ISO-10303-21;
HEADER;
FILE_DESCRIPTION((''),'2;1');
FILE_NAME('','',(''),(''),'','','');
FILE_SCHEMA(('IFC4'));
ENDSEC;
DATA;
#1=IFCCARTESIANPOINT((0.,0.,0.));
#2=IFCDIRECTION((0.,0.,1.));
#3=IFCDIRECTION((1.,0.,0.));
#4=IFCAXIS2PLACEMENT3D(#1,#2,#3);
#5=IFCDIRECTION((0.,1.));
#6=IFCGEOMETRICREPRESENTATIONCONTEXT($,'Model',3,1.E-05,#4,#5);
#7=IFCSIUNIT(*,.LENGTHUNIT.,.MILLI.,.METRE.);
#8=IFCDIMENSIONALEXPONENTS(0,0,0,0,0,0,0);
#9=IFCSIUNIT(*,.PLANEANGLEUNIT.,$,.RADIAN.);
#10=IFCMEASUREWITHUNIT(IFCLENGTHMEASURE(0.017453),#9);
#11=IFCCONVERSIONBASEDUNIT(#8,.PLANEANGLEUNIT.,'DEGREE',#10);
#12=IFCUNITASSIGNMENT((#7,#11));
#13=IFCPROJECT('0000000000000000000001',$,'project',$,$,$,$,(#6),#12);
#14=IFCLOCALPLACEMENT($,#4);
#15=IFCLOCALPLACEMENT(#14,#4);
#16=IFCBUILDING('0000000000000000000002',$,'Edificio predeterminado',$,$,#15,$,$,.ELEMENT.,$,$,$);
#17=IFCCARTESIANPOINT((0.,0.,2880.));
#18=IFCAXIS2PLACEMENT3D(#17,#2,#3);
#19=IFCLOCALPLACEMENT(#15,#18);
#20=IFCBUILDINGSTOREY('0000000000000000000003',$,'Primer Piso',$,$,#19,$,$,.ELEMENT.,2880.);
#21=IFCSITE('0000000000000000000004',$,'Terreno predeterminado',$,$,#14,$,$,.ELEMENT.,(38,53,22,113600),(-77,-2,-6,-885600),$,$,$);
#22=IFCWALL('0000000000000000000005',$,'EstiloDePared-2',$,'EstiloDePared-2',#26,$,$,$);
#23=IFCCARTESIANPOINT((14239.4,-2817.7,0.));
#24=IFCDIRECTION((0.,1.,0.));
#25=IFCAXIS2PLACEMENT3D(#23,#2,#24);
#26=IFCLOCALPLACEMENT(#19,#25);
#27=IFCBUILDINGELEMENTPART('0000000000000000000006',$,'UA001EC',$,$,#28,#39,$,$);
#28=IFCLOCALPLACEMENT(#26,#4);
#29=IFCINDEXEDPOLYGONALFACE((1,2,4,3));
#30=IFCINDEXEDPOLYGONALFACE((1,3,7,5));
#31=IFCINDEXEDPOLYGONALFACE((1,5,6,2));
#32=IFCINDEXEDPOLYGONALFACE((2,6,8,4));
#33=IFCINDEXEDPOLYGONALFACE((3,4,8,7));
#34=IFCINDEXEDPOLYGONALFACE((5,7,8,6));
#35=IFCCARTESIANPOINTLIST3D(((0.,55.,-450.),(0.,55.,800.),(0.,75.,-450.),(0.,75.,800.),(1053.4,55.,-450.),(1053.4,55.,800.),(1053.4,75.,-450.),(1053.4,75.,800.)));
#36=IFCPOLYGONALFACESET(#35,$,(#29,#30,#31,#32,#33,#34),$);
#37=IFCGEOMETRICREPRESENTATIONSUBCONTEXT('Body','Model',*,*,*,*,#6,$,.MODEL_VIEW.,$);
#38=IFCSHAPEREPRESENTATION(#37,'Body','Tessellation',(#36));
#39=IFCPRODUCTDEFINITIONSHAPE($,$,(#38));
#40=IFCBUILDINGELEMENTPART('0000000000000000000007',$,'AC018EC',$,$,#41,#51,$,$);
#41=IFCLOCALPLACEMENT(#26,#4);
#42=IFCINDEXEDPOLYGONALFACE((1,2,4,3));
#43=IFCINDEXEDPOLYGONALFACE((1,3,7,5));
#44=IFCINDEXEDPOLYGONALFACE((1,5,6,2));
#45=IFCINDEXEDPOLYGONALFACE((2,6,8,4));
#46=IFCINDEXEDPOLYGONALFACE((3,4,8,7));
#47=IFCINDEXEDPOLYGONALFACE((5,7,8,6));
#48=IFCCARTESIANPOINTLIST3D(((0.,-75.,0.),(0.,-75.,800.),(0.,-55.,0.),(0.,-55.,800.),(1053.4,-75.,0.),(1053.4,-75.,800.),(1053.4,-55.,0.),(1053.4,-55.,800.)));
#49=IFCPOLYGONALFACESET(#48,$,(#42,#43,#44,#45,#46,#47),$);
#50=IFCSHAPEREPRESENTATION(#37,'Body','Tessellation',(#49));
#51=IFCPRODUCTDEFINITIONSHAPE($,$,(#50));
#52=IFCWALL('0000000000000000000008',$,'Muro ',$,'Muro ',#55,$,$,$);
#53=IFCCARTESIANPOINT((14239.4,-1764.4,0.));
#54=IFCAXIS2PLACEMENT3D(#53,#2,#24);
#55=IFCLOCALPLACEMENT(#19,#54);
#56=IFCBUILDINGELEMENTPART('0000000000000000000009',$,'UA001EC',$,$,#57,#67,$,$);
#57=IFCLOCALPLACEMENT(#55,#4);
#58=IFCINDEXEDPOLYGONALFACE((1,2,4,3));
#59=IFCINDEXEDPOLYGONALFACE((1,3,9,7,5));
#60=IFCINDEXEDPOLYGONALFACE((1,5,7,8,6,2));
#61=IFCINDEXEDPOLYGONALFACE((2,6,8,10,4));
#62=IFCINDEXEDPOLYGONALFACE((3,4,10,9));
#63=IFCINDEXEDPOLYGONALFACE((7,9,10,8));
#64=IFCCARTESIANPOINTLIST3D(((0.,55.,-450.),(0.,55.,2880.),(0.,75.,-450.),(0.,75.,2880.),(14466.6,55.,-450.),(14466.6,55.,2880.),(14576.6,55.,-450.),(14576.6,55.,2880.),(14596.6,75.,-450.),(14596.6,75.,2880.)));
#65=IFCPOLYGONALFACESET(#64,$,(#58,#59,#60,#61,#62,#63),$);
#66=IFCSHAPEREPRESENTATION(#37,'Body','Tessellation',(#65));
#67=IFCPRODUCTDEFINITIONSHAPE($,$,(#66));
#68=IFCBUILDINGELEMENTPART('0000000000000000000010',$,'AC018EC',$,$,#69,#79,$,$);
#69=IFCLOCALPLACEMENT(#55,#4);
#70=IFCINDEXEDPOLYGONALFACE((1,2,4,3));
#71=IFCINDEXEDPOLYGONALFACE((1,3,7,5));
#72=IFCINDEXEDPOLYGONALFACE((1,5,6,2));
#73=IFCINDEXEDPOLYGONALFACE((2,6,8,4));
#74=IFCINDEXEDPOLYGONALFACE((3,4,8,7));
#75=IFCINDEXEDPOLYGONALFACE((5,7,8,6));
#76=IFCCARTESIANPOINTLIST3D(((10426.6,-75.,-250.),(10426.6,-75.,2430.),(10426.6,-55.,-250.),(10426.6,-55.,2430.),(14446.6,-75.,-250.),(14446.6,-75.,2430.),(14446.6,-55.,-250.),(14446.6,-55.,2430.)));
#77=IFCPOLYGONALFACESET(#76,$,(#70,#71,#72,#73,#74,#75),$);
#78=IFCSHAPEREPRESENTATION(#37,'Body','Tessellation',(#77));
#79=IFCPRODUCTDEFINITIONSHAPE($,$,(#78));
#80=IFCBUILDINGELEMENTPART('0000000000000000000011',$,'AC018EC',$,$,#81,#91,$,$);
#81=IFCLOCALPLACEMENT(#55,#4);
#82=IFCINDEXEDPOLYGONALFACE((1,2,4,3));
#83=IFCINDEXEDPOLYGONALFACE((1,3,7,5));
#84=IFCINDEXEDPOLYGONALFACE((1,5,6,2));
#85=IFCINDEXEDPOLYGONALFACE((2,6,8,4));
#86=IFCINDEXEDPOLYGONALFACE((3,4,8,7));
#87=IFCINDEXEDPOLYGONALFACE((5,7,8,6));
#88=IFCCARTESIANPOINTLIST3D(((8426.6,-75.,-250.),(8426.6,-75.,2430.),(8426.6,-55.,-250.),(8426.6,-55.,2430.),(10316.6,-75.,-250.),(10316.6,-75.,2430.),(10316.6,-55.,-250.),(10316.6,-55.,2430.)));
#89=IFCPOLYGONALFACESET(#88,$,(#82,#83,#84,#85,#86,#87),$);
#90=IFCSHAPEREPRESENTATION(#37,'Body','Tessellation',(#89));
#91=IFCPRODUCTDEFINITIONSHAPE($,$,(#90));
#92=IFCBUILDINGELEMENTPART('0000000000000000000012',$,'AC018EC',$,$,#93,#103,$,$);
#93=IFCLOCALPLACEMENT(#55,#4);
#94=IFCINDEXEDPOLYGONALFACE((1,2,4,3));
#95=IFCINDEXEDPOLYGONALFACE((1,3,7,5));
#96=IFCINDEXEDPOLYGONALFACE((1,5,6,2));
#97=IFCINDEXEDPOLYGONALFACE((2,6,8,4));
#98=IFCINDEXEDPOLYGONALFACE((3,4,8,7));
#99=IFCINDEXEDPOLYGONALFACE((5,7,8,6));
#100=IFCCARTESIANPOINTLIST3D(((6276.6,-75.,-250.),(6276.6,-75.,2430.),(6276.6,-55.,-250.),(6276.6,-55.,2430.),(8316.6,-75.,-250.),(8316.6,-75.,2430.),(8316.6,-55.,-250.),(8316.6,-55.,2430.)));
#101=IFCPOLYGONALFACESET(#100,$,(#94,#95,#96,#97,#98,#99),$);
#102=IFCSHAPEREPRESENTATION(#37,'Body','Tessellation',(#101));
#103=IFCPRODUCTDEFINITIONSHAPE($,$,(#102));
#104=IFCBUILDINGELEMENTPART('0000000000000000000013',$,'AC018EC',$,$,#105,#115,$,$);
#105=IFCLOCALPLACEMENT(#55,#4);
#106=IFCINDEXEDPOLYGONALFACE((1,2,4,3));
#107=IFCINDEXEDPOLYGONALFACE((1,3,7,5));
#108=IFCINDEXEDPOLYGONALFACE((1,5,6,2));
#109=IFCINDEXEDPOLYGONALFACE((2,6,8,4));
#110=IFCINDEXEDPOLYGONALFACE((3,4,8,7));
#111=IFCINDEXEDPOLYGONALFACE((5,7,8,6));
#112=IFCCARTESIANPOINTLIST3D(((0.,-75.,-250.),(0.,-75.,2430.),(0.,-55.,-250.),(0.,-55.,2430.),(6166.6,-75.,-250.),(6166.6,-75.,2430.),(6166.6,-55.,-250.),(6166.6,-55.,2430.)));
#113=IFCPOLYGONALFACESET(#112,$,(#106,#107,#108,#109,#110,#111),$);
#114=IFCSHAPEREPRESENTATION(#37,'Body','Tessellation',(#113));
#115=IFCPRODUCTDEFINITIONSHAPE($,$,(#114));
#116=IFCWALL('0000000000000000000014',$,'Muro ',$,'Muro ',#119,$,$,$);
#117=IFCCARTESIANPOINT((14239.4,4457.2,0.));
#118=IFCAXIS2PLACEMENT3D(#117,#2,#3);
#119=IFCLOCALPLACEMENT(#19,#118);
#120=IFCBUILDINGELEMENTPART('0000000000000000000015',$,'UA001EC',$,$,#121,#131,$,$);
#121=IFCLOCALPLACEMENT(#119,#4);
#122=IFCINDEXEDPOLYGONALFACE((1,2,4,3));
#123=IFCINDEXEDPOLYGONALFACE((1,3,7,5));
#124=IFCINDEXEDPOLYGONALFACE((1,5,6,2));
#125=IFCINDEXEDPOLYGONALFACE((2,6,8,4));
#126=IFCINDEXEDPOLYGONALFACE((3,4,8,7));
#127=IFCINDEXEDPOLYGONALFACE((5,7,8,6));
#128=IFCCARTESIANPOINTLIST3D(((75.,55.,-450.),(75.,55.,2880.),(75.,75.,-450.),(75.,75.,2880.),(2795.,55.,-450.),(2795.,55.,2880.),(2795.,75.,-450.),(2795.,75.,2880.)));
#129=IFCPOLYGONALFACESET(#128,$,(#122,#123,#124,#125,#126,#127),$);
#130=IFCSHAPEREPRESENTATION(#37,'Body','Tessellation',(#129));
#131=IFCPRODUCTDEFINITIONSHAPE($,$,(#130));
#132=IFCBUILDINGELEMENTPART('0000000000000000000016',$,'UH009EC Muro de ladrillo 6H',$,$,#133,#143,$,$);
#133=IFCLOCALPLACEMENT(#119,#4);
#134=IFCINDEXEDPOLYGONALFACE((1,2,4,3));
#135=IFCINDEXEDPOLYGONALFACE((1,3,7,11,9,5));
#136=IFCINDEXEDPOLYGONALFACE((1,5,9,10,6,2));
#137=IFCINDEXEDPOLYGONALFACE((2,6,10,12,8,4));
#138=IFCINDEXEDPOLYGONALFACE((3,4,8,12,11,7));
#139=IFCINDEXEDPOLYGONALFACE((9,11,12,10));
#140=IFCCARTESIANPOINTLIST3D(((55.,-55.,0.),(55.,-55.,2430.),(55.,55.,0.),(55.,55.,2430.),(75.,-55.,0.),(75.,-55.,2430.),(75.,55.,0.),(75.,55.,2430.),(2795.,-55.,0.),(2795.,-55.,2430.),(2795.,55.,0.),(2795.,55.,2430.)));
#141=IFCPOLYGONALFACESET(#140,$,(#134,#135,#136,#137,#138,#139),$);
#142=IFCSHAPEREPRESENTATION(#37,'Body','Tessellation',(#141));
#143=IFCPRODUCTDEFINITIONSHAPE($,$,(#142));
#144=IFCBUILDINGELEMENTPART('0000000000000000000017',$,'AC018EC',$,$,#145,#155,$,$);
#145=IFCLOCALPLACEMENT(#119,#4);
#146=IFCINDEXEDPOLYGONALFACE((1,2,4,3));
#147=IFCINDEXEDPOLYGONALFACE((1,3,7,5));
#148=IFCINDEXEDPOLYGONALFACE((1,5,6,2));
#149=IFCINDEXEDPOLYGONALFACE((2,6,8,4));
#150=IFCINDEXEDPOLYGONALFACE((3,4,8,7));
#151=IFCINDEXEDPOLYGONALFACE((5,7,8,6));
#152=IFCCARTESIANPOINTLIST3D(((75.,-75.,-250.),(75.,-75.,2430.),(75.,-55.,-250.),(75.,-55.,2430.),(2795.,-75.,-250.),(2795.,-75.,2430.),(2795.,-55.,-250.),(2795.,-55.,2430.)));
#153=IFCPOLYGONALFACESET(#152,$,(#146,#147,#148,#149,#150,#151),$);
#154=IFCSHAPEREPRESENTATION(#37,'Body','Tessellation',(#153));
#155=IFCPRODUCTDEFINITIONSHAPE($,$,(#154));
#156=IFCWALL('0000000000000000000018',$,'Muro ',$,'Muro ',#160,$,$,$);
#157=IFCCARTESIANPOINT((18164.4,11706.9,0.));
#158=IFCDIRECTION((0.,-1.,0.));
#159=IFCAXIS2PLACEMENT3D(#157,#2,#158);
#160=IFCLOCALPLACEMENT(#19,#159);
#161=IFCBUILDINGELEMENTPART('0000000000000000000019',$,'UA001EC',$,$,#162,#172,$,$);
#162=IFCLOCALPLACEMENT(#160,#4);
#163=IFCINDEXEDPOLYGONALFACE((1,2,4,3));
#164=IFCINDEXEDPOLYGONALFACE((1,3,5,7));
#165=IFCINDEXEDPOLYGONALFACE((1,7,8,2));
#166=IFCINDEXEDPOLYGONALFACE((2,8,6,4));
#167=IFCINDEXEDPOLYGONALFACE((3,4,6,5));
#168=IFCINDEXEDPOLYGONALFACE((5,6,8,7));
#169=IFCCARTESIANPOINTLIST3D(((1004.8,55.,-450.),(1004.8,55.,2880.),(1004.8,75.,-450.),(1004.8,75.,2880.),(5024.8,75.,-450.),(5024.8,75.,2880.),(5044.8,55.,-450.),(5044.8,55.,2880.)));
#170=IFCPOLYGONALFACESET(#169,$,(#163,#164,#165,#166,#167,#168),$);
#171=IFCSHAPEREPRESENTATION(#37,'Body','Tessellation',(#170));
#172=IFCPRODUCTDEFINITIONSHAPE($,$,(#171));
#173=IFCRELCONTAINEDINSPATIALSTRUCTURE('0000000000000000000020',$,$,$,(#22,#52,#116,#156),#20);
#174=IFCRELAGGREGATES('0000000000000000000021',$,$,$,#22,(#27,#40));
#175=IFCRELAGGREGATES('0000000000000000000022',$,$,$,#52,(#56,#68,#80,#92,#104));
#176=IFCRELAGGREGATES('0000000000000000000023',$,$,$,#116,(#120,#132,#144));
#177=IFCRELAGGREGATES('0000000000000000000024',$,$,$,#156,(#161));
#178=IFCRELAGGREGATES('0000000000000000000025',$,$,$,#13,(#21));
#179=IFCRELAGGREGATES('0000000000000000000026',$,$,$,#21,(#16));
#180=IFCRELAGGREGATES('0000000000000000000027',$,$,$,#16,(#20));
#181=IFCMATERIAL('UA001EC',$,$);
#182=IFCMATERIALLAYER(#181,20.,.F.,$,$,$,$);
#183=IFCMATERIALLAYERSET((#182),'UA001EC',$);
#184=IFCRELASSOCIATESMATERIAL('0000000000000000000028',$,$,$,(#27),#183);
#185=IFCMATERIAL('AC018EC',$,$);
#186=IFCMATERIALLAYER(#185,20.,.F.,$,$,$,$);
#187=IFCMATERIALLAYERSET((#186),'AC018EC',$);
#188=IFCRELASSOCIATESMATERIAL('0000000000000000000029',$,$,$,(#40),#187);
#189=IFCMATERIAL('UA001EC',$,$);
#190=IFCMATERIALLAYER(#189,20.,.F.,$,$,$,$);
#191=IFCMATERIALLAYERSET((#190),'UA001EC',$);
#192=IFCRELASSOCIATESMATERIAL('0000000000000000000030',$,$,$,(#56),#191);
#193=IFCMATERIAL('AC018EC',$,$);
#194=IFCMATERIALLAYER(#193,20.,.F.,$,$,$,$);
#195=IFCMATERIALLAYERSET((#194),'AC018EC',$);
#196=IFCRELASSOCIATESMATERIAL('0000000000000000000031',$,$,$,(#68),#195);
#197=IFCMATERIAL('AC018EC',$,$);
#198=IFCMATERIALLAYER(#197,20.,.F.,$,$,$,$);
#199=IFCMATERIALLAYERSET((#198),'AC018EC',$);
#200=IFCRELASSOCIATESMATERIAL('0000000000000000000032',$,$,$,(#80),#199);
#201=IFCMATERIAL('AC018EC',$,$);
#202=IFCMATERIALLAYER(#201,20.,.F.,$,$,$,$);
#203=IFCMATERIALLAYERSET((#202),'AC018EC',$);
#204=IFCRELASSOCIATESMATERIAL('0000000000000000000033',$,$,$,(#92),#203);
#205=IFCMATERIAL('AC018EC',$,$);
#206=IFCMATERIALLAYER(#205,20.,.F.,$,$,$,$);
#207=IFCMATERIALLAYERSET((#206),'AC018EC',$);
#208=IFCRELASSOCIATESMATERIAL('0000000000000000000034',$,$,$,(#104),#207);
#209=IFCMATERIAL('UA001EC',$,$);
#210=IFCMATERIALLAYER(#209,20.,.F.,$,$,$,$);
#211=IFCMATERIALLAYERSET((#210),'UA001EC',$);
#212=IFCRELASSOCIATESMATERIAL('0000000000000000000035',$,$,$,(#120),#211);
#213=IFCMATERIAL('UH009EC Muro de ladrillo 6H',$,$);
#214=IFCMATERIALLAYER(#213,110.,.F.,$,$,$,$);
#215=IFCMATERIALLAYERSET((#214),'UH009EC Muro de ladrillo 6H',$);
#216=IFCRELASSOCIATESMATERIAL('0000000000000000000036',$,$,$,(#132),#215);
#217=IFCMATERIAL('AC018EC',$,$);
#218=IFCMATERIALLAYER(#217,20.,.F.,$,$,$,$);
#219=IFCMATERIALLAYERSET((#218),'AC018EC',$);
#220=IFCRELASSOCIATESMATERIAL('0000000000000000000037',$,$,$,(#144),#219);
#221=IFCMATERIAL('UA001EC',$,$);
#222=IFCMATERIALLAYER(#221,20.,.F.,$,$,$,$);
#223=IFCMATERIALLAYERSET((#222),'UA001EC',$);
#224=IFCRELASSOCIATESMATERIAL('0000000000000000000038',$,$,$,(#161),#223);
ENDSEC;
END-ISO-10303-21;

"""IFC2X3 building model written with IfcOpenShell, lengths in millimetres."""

from ifc_helpers import new_model, entity, si_unit, converted_unit, direction, frame, origin_with_axes, place, context, subcontext, project, spatial, polyline, outline, extrude, material, layer, layer_set, layer_usage, element, aggregate, save


model = new_model("IFC2X3")

# Units and contexts
model_context = context("Model", 3, precision=1e-05, world=origin_with_axes(), true_north=direction((0.0, 1.0)))
body_context = subcontext(model_context, "Body", "Model", "MODEL_VIEW")
ifc_project = project(units=[si_unit("LENGTHUNIT", "METRE", prefix="MILLI"), converted_unit("PLANEANGLEUNIT", "DEGREE", entity("IfcLengthMeasure", 0.017453), si_unit("PLANEANGLEUNIT", "RADIAN"), dimensions=[0, 0, 0, 0, 0, 0, 0])], contexts=[model_context])

# Site, building, storey
site_placement = place(None, origin_with_axes())
site = spatial("IfcSite", under=ifc_project, at=site_placement, Name="Terreno predeterminado", CompositionType="ELEMENT", RefLatitude=(38, 53, 22, 113600), RefLongitude=(-77, -2, -6, -885600))
building_placement = place(site_placement, origin_with_axes())
building = spatial("IfcBuilding", under=site, at=building_placement, Name="Edificio predeterminado", CompositionType="ELEMENT")
storey_placement = place(building_placement, frame((0.0, 0.0, 2880.0), z_axis=(0.0, 0.0, 1.0), x_axis=(1.0, 0.0, 0.0)))
storey = spatial("IfcBuildingStorey", under=building, at=storey_placement, Name="Primer Piso", CompositionType="ELEMENT", Elevation=2880.0)

# Walls, building element parts
wall_1_placement = place(storey_placement, frame((14239.4, -2817.7, 0.0), z_axis=(0.0, 0.0, 1.0), x_axis=(0.0, 1.0, 0.0)))
wall_1 = element("IfcWall", 1, at=wall_1_placement, inside=storey, Name="EstiloDePared-2", ObjectType="EstiloDePared-2")
ifc_material_1 = material(Name="UA001EC")
ifc_layer_1 = layer(ifc_material_1, 20.0, ventilated=False)
ifc_layer_set_1 = layer_set([ifc_layer_1], Name="UA001EC")
ifc_layer_usage_1 = layer_usage(ifc_layer_set_1, "AXIS2", "NEGATIVE", -75.0)
building_element_part_1_placement = place(wall_1_placement, origin_with_axes())
building_element_part_1 = element("IfcBuildingElementPart", 2, at=building_element_part_1_placement, material=ifc_layer_usage_1, Name="UA001EC", context=body_context, shape_type="SweptSolid", body=[
    extrude(outline(polyline([(1053.4, 75.0), (1053.4, 55.0), (0.0, 55.0), (0.0, 75.0), (1053.4, 75.0)])), frame((0.0, 0.0, -450.0), z_axis=(0.0, 0.0, 1.0), x_axis=(1.0, 0.0, 0.0)), (0.0, 0.0, 1.0), 1250.0),
])
ifc_material_2 = material(Name="AC018EC")
ifc_layer_2 = layer(ifc_material_2, 20.0, ventilated=False)
ifc_layer_set_2 = layer_set([ifc_layer_2], Name="AC018EC")
ifc_layer_usage_2 = layer_usage(ifc_layer_set_2, "AXIS2", "NEGATIVE", 55.0)
building_element_part_2_placement = place(wall_1_placement, origin_with_axes())
building_element_part_2 = element("IfcBuildingElementPart", 3, at=building_element_part_2_placement, material=ifc_layer_usage_2, Name="AC018EC", context=body_context, shape_type="SweptSolid", body=[
    extrude(outline(polyline([(1053.4, -55.0), (1053.4, -75.0), (0.0, -75.0), (0.0, -55.0), (1053.4, -55.0)])), origin_with_axes(), (0.0, 0.0, 1.0), 800.0),
])
aggregate(wall_1, [building_element_part_1, building_element_part_2])
wall_2_placement = place(storey_placement, frame((14239.4, -1764.4, 0.0), z_axis=(0.0, 0.0, 1.0), x_axis=(0.0, 1.0, 0.0)))
wall_2 = element("IfcWall", 4, at=wall_2_placement, inside=storey, Name="Muro ", ObjectType="Muro ")
ifc_material_3 = material(Name="UA001EC")
ifc_layer_3 = layer(ifc_material_3, 20.0, ventilated=False)
ifc_layer_set_3 = layer_set([ifc_layer_3], Name="UA001EC")
ifc_layer_usage_3 = layer_usage(ifc_layer_set_3, "AXIS2", "NEGATIVE", -75.0)
building_element_part_3_placement = place(wall_2_placement, origin_with_axes())
building_element_part_3 = element("IfcBuildingElementPart", 5, at=building_element_part_3_placement, material=ifc_layer_usage_3, Name="UA001EC", context=body_context, shape_type="SweptSolid", body=[
    extrude(outline(polyline([(14596.6, 75.0), (14576.6, 55.0), (14466.6, 55.0), (0.0, 55.0), (0.0, 75.0), (14596.6, 75.0)])), frame((0.0, 0.0, -450.0), z_axis=(0.0, 0.0, 1.0), x_axis=(1.0, 0.0, 0.0)), (0.0, 0.0, 1.0), 3330.0),
])
ifc_material_4 = material(Name="AC018EC")
ifc_layer_4 = layer(ifc_material_4, 20.0, ventilated=False)
ifc_layer_set_4 = layer_set([ifc_layer_4], Name="AC018EC")
ifc_layer_usage_4 = layer_usage(ifc_layer_set_4, "AXIS2", "NEGATIVE", 55.0)
building_element_part_4_placement = place(wall_2_placement, origin_with_axes())
building_element_part_4 = element("IfcBuildingElementPart", 6, at=building_element_part_4_placement, material=ifc_layer_usage_4, Name="AC018EC", context=body_context, shape_type="SweptSolid", body=[
    extrude(outline(polyline([(14446.6, -55.0), (14446.6, -75.0), (10426.6, -75.0), (10426.6, -55.0), (14446.6, -55.0)])), frame((0.0, 0.0, -250.0), z_axis=(0.0, 0.0, 1.0), x_axis=(1.0, 0.0, 0.0)), (0.0, 0.0, 1.0), 2680.0),
])
ifc_material_5 = material(Name="AC018EC")
ifc_layer_5 = layer(ifc_material_5, 20.0, ventilated=False)
ifc_layer_set_5 = layer_set([ifc_layer_5], Name="AC018EC")
ifc_layer_usage_5 = layer_usage(ifc_layer_set_5, "AXIS2", "NEGATIVE", 55.0)
building_element_part_5_placement = place(wall_2_placement, origin_with_axes())
building_element_part_5 = element("IfcBuildingElementPart", 7, at=building_element_part_5_placement, material=ifc_layer_usage_5, Name="AC018EC", context=body_context, shape_type="SweptSolid", body=[
    extrude(outline(polyline([(10316.6, -55.0), (10316.6, -75.0), (8426.6, -75.0), (8426.6, -55.0), (10316.6, -55.0)])), frame((0.0, 0.0, -250.0), z_axis=(0.0, 0.0, 1.0), x_axis=(1.0, 0.0, 0.0)), (0.0, 0.0, 1.0), 2680.0),
])
ifc_material_6 = material(Name="AC018EC")
ifc_layer_6 = layer(ifc_material_6, 20.0, ventilated=False)
ifc_layer_set_6 = layer_set([ifc_layer_6], Name="AC018EC")
ifc_layer_usage_6 = layer_usage(ifc_layer_set_6, "AXIS2", "NEGATIVE", 55.0)
building_element_part_6_placement = place(wall_2_placement, origin_with_axes())
building_element_part_6 = element("IfcBuildingElementPart", 8, at=building_element_part_6_placement, material=ifc_layer_usage_6, Name="AC018EC", context=body_context, shape_type="SweptSolid", body=[
    extrude(outline(polyline([(8316.6, -55.0), (8316.6, -75.0), (6276.6, -75.0), (6276.6, -55.0), (8316.6, -55.0)])), frame((0.0, 0.0, -250.0), z_axis=(0.0, 0.0, 1.0), x_axis=(1.0, 0.0, 0.0)), (0.0, 0.0, 1.0), 2680.0),
])
ifc_material_7 = material(Name="AC018EC")
ifc_layer_7 = layer(ifc_material_7, 20.0, ventilated=False)
ifc_layer_set_7 = layer_set([ifc_layer_7], Name="AC018EC")
ifc_layer_usage_7 = layer_usage(ifc_layer_set_7, "AXIS2", "NEGATIVE", 55.0)
building_element_part_7_placement = place(wall_2_placement, origin_with_axes())
building_element_part_7 = element("IfcBuildingElementPart", 9, at=building_element_part_7_placement, material=ifc_layer_usage_7, Name="AC018EC", context=body_context, shape_type="SweptSolid", body=[
    extrude(outline(polyline([(6166.6, -55.0), (6166.6, -75.0), (0.0, -75.0), (0.0, -55.0), (6166.6, -55.0)])), frame((0.0, 0.0, -250.0), z_axis=(0.0, 0.0, 1.0), x_axis=(1.0, 0.0, 0.0)), (0.0, 0.0, 1.0), 2680.0),
])
aggregate(wall_2, [building_element_part_3, building_element_part_4, building_element_part_5, building_element_part_6, building_element_part_7])
wall_3_placement = place(storey_placement, frame((14239.4, 4457.2, 0.0), z_axis=(0.0, 0.0, 1.0), x_axis=(1.0, 0.0, 0.0)))
wall_3 = element("IfcWall", 10, at=wall_3_placement, inside=storey, Name="Muro ", ObjectType="Muro ")
ifc_material_8 = material(Name="UA001EC")
ifc_layer_8 = layer(ifc_material_8, 20.0, ventilated=False)
ifc_layer_set_8 = layer_set([ifc_layer_8], Name="UA001EC")
ifc_layer_usage_8 = layer_usage(ifc_layer_set_8, "AXIS2", "NEGATIVE", -75.0)
building_element_part_8_placement = place(wall_3_placement, origin_with_axes())
building_element_part_8 = element("IfcBuildingElementPart", 11, at=building_element_part_8_placement, material=ifc_layer_usage_8, Name="UA001EC", context=body_context, shape_type="SweptSolid", body=[
    extrude(outline(polyline([(2795.0, 75.0), (2795.0, 55.0), (75.0, 55.0), (75.0, 75.0), (2795.0, 75.0)])), frame((0.0, 0.0, -450.0), z_axis=(0.0, 0.0, 1.0), x_axis=(1.0, 0.0, 0.0)), (0.0, 0.0, 1.0), 3330.0),
])
ifc_material_9 = material(Name="UH009EC Muro de ladrillo 6H")
ifc_layer_9 = layer(ifc_material_9, 110.0, ventilated=False)
ifc_layer_set_9 = layer_set([ifc_layer_9], Name="UH009EC Muro de ladrillo 6H")
ifc_layer_usage_9 = layer_usage(ifc_layer_set_9, "AXIS2", "NEGATIVE", -55.0)
building_element_part_9_placement = place(wall_3_placement, origin_with_axes())
building_element_part_9 = element("IfcBuildingElementPart", 12, at=building_element_part_9_placement, material=ifc_layer_usage_9, Name="UH009EC Muro de ladrillo 6H", context=body_context, shape_type="SweptSolid", body=[
    extrude(outline(polyline([(2795.0, 55.0), (2795.0, -55.0), (75.0, -55.0), (55.0, -55.0), (55.0, 55.0), (75.0, 55.0), (2795.0, 55.0)])), origin_with_axes(), (0.0, 0.0, 1.0), 2430.0),
])
ifc_material_10 = material(Name="AC018EC")
ifc_layer_10 = layer(ifc_material_10, 20.0, ventilated=False)
ifc_layer_set_10 = layer_set([ifc_layer_10], Name="AC018EC")
ifc_layer_usage_10 = layer_usage(ifc_layer_set_10, "AXIS2", "NEGATIVE", 55.0)
building_element_part_10_placement = place(wall_3_placement, origin_with_axes())
building_element_part_10 = element("IfcBuildingElementPart", 13, at=building_element_part_10_placement, material=ifc_layer_usage_10, Name="AC018EC", context=body_context, shape_type="SweptSolid", body=[
    extrude(outline(polyline([(75.0, -55.0), (2795.0, -55.0), (2795.0, -75.0), (75.0, -75.0), (75.0, -55.0)])), frame((0.0, 0.0, -250.0), z_axis=(0.0, 0.0, 1.0), x_axis=(1.0, 0.0, 0.0)), (0.0, 0.0, 1.0), 2680.0),
])
aggregate(wall_3, [building_element_part_8, building_element_part_9, building_element_part_10])
wall_4_placement = place(storey_placement, frame((18164.4, 11706.9, 0.0), z_axis=(0.0, 0.0, 1.0), x_axis=(0.0, -1.0, 0.0)))
wall_4 = element("IfcWall", 14, at=wall_4_placement, inside=storey, Name="Muro ", ObjectType="Muro ")
ifc_material_11 = material(Name="UA001EC")
ifc_layer_11 = layer(ifc_material_11, 20.0, ventilated=False)
ifc_layer_set_11 = layer_set([ifc_layer_11], Name="UA001EC")
ifc_layer_usage_11 = layer_usage(ifc_layer_set_11, "AXIS2", "NEGATIVE", -75.0)
building_element_part_11_placement = place(wall_4_placement, origin_with_axes())
building_element_part_11 = element("IfcBuildingElementPart", 15, at=building_element_part_11_placement, material=ifc_layer_usage_11, Name="UA001EC", context=body_context, shape_type="SweptSolid", body=[
    extrude(outline(polyline([(5024.8, 75.0), (5044.8, 55.0), (1004.8, 55.0), (1004.8, 75.0), (5024.8, 75.0)])), frame((0.0, 0.0, -450.0), z_axis=(0.0, 0.0, 1.0), x_axis=(1.0, 0.0, 0.0)), (0.0, 0.0, 1.0), 3330.0),
])
aggregate(wall_4, [building_element_part_11])

save(model, "model.ifc")
